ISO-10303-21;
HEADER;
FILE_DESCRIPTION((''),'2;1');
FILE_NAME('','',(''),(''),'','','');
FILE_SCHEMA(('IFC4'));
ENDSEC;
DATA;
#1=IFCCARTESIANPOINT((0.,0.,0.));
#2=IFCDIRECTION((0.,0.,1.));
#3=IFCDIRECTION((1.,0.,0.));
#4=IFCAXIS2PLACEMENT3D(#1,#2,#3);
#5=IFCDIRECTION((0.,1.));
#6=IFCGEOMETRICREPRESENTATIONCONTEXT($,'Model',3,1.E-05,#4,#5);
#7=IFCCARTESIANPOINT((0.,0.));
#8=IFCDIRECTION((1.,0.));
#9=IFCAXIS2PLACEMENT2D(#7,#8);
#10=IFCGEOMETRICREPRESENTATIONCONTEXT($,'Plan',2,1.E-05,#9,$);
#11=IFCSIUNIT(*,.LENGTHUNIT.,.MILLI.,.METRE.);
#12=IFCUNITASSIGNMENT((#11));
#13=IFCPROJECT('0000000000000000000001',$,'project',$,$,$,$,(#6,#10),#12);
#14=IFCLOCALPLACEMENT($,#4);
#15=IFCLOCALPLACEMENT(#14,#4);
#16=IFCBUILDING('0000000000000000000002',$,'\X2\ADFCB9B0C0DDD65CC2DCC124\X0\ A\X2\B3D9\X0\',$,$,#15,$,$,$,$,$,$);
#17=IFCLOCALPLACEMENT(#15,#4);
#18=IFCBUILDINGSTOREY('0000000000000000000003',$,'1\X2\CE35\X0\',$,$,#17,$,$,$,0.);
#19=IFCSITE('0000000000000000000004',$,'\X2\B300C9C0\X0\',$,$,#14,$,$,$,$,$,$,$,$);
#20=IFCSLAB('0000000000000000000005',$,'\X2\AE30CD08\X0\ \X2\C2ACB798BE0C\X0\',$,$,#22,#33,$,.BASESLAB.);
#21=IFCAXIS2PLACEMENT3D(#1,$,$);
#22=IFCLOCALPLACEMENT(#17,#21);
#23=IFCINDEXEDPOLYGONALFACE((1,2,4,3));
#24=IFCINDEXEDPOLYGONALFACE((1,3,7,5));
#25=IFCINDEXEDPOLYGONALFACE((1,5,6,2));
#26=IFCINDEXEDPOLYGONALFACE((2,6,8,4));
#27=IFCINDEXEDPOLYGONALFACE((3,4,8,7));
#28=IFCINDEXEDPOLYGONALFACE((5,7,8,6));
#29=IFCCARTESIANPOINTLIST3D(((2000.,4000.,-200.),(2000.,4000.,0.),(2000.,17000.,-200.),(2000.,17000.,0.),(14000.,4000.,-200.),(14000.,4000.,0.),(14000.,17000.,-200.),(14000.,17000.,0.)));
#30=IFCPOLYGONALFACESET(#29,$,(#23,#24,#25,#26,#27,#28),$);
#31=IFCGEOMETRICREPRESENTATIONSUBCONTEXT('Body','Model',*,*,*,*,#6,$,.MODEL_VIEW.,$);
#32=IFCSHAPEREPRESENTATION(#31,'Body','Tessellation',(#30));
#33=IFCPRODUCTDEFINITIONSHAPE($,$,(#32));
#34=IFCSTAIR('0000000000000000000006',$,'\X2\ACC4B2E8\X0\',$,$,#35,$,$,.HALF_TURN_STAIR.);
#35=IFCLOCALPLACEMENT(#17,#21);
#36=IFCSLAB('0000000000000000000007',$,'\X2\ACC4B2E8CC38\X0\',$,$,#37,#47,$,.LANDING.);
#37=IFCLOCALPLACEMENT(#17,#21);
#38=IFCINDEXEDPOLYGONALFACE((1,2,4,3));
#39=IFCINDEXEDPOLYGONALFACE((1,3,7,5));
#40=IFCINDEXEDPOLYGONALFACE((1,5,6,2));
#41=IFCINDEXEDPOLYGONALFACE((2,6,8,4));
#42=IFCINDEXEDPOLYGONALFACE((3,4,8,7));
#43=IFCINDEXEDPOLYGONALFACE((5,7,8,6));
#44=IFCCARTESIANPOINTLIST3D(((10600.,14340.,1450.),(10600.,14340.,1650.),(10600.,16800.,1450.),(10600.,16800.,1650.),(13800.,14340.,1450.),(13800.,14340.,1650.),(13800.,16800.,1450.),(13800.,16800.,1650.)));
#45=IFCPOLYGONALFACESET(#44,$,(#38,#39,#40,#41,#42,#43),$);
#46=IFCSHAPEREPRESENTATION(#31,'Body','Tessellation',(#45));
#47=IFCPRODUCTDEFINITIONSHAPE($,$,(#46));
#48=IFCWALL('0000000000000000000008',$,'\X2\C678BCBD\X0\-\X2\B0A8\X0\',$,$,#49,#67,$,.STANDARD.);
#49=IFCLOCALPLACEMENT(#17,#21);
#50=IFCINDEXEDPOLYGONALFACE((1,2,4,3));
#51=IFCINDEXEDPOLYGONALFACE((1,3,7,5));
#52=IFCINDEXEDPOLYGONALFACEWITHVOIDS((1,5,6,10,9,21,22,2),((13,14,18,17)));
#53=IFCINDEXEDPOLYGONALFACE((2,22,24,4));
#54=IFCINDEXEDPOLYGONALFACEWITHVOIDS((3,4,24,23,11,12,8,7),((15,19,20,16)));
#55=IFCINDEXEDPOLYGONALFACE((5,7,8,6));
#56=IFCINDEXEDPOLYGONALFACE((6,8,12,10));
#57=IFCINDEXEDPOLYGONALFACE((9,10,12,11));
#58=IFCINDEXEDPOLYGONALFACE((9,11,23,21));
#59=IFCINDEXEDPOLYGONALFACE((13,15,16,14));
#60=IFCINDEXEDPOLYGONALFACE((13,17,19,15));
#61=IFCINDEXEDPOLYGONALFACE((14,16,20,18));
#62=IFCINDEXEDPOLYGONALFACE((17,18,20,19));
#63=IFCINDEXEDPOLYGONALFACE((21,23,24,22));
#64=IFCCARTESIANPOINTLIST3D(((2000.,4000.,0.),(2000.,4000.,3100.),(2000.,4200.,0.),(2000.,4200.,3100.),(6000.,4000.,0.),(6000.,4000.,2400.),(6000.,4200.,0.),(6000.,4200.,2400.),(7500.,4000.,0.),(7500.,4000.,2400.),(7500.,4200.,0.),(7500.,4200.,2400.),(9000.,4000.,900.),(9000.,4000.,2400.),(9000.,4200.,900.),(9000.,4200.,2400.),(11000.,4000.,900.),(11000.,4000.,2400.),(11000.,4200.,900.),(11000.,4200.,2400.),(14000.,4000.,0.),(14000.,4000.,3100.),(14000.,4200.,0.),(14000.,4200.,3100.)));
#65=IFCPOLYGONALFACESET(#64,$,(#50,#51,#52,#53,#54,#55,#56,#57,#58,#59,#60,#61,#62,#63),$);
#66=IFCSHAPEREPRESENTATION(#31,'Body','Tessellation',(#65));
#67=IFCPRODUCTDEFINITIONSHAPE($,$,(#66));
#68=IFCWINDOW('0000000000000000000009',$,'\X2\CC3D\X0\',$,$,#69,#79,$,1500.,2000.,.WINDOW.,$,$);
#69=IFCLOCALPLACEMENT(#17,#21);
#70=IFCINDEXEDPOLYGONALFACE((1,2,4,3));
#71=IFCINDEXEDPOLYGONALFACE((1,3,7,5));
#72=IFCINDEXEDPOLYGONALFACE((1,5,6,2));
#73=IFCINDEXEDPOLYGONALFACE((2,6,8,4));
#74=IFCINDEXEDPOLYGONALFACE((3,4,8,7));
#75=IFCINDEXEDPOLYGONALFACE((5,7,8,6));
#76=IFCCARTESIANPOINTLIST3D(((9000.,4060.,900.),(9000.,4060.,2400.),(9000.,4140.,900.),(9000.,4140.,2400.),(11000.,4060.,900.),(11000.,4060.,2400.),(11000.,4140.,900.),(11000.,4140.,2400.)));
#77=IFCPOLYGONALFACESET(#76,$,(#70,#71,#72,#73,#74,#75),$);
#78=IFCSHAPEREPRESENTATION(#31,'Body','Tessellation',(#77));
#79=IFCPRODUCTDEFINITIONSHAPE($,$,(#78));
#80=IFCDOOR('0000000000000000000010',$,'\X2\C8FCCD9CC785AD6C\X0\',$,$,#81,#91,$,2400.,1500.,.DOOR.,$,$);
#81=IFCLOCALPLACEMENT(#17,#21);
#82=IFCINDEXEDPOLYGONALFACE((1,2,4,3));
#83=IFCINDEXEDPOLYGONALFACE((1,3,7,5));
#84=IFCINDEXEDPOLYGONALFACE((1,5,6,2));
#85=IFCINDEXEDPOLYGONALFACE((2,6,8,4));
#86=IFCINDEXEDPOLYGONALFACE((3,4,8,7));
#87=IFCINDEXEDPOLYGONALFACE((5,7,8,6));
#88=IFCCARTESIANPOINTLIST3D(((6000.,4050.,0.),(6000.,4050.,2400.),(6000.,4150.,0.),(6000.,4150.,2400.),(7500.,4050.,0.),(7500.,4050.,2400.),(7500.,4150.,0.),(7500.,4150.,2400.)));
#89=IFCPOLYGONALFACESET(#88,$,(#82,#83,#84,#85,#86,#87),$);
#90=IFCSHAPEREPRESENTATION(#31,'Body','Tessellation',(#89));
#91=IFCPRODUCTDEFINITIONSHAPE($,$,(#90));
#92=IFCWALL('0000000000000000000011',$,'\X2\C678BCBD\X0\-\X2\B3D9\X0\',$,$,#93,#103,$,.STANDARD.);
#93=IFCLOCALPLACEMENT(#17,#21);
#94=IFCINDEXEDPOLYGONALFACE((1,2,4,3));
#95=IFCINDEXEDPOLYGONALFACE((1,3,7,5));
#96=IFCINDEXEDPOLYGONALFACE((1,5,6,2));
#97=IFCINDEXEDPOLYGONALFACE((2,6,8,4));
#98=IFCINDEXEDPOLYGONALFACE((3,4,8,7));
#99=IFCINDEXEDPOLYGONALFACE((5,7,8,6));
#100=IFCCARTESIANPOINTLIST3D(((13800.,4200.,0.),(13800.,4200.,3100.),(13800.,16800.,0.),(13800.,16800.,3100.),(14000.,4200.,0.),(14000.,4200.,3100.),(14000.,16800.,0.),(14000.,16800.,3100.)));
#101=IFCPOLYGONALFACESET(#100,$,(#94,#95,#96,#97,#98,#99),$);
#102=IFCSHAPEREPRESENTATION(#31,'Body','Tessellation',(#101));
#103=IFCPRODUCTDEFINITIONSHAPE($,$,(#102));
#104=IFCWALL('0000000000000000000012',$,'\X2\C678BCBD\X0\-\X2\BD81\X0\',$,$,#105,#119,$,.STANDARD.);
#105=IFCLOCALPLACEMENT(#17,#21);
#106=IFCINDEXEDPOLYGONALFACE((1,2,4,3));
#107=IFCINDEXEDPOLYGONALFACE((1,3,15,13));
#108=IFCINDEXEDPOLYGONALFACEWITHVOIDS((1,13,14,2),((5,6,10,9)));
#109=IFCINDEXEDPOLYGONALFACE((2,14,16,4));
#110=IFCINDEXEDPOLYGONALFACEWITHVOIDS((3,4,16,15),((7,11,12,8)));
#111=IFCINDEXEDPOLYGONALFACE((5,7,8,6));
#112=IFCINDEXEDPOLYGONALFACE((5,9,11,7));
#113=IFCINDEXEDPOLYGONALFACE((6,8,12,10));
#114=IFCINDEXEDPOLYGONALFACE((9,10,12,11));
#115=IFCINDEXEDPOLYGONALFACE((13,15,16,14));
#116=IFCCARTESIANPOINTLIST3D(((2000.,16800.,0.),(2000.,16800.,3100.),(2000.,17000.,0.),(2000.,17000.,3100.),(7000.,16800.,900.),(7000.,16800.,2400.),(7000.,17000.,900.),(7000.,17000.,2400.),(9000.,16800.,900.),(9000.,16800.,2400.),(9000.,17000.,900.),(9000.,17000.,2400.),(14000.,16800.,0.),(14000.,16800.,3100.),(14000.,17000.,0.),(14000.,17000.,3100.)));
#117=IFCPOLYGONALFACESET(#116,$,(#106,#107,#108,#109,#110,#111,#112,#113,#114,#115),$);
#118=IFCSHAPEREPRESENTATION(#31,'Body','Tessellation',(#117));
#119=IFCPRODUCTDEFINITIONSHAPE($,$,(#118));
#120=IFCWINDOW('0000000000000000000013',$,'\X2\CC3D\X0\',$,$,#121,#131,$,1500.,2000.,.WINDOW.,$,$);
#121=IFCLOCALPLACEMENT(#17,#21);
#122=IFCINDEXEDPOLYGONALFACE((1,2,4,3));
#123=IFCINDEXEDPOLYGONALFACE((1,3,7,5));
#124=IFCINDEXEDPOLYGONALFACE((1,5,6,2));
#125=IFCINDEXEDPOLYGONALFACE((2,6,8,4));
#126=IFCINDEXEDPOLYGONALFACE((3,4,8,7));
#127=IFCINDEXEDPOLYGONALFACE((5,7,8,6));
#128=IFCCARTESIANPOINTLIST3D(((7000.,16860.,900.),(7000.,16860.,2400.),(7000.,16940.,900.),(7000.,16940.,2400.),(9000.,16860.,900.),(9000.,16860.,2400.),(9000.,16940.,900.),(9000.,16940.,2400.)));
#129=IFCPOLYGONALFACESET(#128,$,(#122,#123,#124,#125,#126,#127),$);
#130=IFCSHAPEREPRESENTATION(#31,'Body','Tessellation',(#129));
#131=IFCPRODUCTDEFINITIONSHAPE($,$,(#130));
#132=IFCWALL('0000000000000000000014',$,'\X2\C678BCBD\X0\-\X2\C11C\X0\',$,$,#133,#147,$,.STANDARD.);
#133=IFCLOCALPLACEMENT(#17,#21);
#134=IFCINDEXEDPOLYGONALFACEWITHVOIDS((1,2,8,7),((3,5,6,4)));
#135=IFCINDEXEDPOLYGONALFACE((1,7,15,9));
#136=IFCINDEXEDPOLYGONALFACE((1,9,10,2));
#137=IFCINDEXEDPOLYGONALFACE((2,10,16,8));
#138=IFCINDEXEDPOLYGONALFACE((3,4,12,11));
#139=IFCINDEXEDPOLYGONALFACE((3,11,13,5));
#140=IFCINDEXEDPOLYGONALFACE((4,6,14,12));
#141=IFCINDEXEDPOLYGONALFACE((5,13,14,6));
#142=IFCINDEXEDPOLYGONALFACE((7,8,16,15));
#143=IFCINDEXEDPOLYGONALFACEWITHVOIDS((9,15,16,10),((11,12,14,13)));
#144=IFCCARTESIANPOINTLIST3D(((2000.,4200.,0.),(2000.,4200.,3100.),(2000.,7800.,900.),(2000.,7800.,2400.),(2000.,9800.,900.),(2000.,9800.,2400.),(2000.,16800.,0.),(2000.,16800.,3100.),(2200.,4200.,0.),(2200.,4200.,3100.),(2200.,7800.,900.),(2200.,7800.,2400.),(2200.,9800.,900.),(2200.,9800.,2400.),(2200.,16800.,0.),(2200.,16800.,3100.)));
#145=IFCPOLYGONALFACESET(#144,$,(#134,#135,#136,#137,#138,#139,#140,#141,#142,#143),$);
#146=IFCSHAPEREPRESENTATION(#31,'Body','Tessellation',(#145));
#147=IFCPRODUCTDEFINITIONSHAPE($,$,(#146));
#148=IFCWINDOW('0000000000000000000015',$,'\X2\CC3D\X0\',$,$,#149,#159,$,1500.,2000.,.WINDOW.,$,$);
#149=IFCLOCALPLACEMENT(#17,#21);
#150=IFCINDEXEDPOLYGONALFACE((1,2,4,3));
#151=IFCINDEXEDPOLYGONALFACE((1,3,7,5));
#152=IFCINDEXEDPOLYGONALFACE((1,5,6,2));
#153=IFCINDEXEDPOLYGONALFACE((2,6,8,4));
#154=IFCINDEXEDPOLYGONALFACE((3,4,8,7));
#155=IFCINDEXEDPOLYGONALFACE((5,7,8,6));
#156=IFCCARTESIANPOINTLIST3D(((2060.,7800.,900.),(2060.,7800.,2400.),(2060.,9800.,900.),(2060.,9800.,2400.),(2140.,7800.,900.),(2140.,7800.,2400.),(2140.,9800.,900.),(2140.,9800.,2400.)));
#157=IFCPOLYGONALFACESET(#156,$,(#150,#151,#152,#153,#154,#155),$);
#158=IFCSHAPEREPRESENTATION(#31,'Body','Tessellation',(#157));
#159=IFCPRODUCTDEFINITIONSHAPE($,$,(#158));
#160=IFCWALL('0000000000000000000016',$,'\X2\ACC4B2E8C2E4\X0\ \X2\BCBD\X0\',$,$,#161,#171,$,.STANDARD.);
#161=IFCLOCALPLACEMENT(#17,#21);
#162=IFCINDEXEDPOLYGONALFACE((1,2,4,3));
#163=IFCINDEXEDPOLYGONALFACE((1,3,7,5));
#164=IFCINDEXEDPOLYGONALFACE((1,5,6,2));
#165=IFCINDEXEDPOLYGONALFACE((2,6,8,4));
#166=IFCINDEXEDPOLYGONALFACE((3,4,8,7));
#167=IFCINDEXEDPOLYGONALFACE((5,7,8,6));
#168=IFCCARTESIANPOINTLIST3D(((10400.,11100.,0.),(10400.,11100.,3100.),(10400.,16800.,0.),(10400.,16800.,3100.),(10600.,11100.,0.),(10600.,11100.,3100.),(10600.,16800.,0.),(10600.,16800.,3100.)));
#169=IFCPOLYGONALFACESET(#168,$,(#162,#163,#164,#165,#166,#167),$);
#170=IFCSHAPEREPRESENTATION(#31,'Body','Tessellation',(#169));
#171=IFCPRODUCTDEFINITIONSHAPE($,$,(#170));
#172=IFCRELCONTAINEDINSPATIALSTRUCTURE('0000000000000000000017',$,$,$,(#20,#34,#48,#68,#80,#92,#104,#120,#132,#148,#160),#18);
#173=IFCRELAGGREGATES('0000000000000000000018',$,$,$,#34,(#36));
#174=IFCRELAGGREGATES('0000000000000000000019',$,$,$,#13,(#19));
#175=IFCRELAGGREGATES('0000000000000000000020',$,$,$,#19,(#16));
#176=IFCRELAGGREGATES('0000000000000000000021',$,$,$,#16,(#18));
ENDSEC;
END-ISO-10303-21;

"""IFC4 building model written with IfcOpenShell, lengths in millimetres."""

from ifc_helpers import new_model, si_unit, direction, frame, origin_with_axes, origin_2d_with_axis, place, context, subcontext, project, spatial, polyline, outline, extrude, element, fill, aggregate, save


model = new_model("IFC4")

# Units and contexts
model_context = context("Model", 3, precision=1e-05, world=origin_with_axes(), true_north=direction((0.0, 1.0)))
plan_context = context("Plan", 2, precision=1e-05, world=origin_2d_with_axis())
body_context = subcontext(model_context, "Body", "Model", "MODEL_VIEW")
ifc_project = project(units=[si_unit("LENGTHUNIT", "METRE", prefix="MILLI")], contexts=[model_context, plan_context])

# Site, building, storey
site_placement = place(None, origin_with_axes())
site = spatial("IfcSite", under=ifc_project, at=site_placement, Name="대지")
building_placement = place(site_placement, origin_with_axes())
building = spatial("IfcBuilding", under=site, at=building_placement, Name="근린생활시설 A동")
storey_placement = place(building_placement, origin_with_axes())
storey = spatial("IfcBuildingStorey", under=building, at=storey_placement, Name="1층", Elevation=0.0)

# Slab
slab_1_placement = place(storey_placement, origin_with_axes())
element("IfcSlab", 1, at=slab_1_placement, inside=storey, Name="기초 슬래브", PredefinedType="BASESLAB", context=body_context, shape_type="SweptSolid", body=[
    extrude(outline(polyline([(2000.0, 4000.0), (14000.0, 4000.0), (14000.0, 17000.0), (2000.0, 17000.0), (2000.0, 4000.0)])), frame((0.0, 0.0, -200.0), z_axis=(0.0, 0.0, 1.0), x_axis=(1.0, 0.0, 0.0)), (0.0, 0.0, 1.0), 200.0),
])

# Stair, slab
stair_placement = place(storey_placement, origin_with_axes())
stair = element("IfcStair", 2, at=stair_placement, inside=storey, Name="계단", PredefinedType="HALF_TURN_STAIR")
slab_2_placement = place(stair_placement, origin_with_axes())
slab_2 = element("IfcSlab", 3, at=slab_2_placement, Name="계단참", PredefinedType="LANDING", context=body_context, shape_type="SweptSolid", body=[
    extrude(outline(polyline([(10600.0, 14340.0), (13800.0, 14340.0), (13800.0, 16800.0), (10600.0, 16800.0), (10600.0, 14340.0)])), frame((0.0, 0.0, 1450.0), z_axis=(0.0, 0.0, 1.0), x_axis=(1.0, 0.0, 0.0)), (0.0, 0.0, 1.0), 200.0),
])

# Wall, openings, window, door
wall_1_placement = place(storey_placement, origin_with_axes())
wall_1 = element("IfcWall", 4, at=wall_1_placement, inside=storey, Name="외벽-남", PredefinedType="STANDARD", context=body_context, shape_type="SweptSolid", body=[
    extrude(outline(polyline([(2000.0, 4200.0), (14000.0, 4200.0), (14000.0, 4000.0), (2000.0, 4000.0), (2000.0, 4200.0)])), origin_with_axes(), (0.0, 0.0, 1.0), 3100.0),
])
opening_1_placement = place(storey_placement, origin_with_axes())
opening_1 = element("IfcOpeningElement", 5, at=opening_1_placement, cuts=wall_1, PredefinedType="OPENING", context=body_context, shape_type="SweptSolid", body=[
    extrude(outline(polyline([(9000.0, 3950.0), (11000.0, 3950.0), (11000.0, 4250.0), (9000.0, 4250.0), (9000.0, 3950.0)])), frame((0.0, 0.0, 900.0), z_axis=(0.0, 0.0, 1.0), x_axis=(1.0, 0.0, 0.0)), (0.0, 0.0, 1.0), 1500.0),
])
opening_2_placement = place(storey_placement, origin_with_axes())
opening_2 = element("IfcOpeningElement", 6, at=opening_2_placement, cuts=wall_1, PredefinedType="OPENING", context=body_context, shape_type="SweptSolid", body=[
    extrude(outline(polyline([(6000.0, 3950.0), (7500.0, 3950.0), (7500.0, 4250.0), (6000.0, 4250.0), (6000.0, 3950.0)])), origin_with_axes(), (0.0, 0.0, 1.0), 2400.0),
])
window_1_placement = place(storey_placement, origin_with_axes())
window_1 = element("IfcWindow", 7, at=window_1_placement, inside=storey, Name="창", OverallHeight=1500.0, OverallWidth=2000.0, PredefinedType="WINDOW", context=body_context, shape_type="SweptSolid", body=[
    extrude(outline(polyline([(9000.0, 4060.0), (11000.0, 4060.0), (11000.0, 4140.0), (9000.0, 4140.0), (9000.0, 4060.0)])), frame((0.0, 0.0, 900.0), z_axis=(0.0, 0.0, 1.0), x_axis=(1.0, 0.0, 0.0)), (0.0, 0.0, 1.0), 1500.0),
])
fill(opening_1, window_1)
door_1_placement = place(storey_placement, origin_with_axes())
door_1 = element("IfcDoor", 8, at=door_1_placement, inside=storey, Name="주출입구", OverallHeight=2400.0, OverallWidth=1500.0, PredefinedType="DOOR", context=body_context, shape_type="SweptSolid", body=[
    extrude(outline(polyline([(6000.0, 4050.0), (7500.0, 4050.0), (7500.0, 4150.0), (6000.0, 4150.0), (6000.0, 4050.0)])), origin_with_axes(), (0.0, 0.0, 1.0), 2400.0),
])
fill(opening_2, door_1)

# Wall
wall_2_placement = place(storey_placement, origin_with_axes())
element("IfcWall", 9, at=wall_2_placement, inside=storey, Name="외벽-동", PredefinedType="STANDARD", context=body_context, shape_type="SweptSolid", body=[
    extrude(outline(polyline([(13800.0, 4200.0), (13800.0, 16800.0), (14000.0, 16800.0), (14000.0, 4200.0), (13800.0, 4200.0)])), origin_with_axes(), (0.0, 0.0, 1.0), 3100.0),
])

# Walls, openings, windows
wall_3_placement = place(storey_placement, origin_with_axes())
wall_3 = element("IfcWall", 10, at=wall_3_placement, inside=storey, Name="외벽-북", PredefinedType="STANDARD", context=body_context, shape_type="SweptSolid", body=[
    extrude(outline(polyline([(14000.0, 16800.0), (2000.0, 16800.0), (2000.0, 17000.0), (14000.0, 17000.0), (14000.0, 16800.0)])), origin_with_axes(), (0.0, 0.0, 1.0), 3100.0),
])
opening_3_placement = place(storey_placement, origin_with_axes())
opening_3 = element("IfcOpeningElement", 11, at=opening_3_placement, cuts=wall_3, PredefinedType="OPENING", context=body_context, shape_type="SweptSolid", body=[
    extrude(outline(polyline([(9000.0, 17050.0), (7000.0, 17050.0), (7000.0, 16750.0), (9000.0, 16750.0), (9000.0, 17050.0)])), frame((0.0, 0.0, 900.0), z_axis=(0.0, 0.0, 1.0), x_axis=(1.0, 0.0, 0.0)), (0.0, 0.0, 1.0), 1500.0),
])
window_2_placement = place(storey_placement, origin_with_axes())
window_2 = element("IfcWindow", 12, at=window_2_placement, inside=storey, Name="창", OverallHeight=1500.0, OverallWidth=2000.0, PredefinedType="WINDOW", context=body_context, shape_type="SweptSolid", body=[
    extrude(outline(polyline([(9000.0, 16940.0), (7000.0, 16940.0), (7000.0, 16860.0), (9000.0, 16860.0), (9000.0, 16940.0)])), frame((0.0, 0.0, 900.0), z_axis=(0.0, 0.0, 1.0), x_axis=(1.0, 0.0, 0.0)), (0.0, 0.0, 1.0), 1500.0),
])
fill(opening_3, window_2)
wall_4_placement = place(storey_placement, origin_with_axes())
wall_4 = element("IfcWall", 13, at=wall_4_placement, inside=storey, Name="외벽-서", PredefinedType="STANDARD", context=body_context, shape_type="SweptSolid", body=[
    extrude(outline(polyline([(2200.0, 16800.0), (2200.0, 4200.0), (2000.0, 4200.0), (2000.0, 16800.0), (2200.0, 16800.0)])), origin_with_axes(), (0.0, 0.0, 1.0), 3100.0),
])
opening_4_placement = place(storey_placement, origin_with_axes())
opening_4 = element("IfcOpeningElement", 14, at=opening_4_placement, cuts=wall_4, PredefinedType="OPENING", context=body_context, shape_type="SweptSolid", body=[
    extrude(outline(polyline([(1950.0, 9800.0), (1950.0, 7800.0), (2250.0, 7800.0), (2250.0, 9800.0), (1950.0, 9800.0)])), frame((0.0, 0.0, 900.0), z_axis=(0.0, 0.0, 1.0), x_axis=(1.0, 0.0, 0.0)), (0.0, 0.0, 1.0), 1500.0),
])
window_3_placement = place(storey_placement, origin_with_axes())
window_3 = element("IfcWindow", 15, at=window_3_placement, inside=storey, Name="창", OverallHeight=1500.0, OverallWidth=2000.0, PredefinedType="WINDOW", context=body_context, shape_type="SweptSolid", body=[
    extrude(outline(polyline([(2060.0, 9800.0), (2060.0, 7800.0), (2140.0, 7800.0), (2140.0, 9800.0), (2060.0, 9800.0)])), frame((0.0, 0.0, 900.0), z_axis=(0.0, 0.0, 1.0), x_axis=(1.0, 0.0, 0.0)), (0.0, 0.0, 1.0), 1500.0),
])
fill(opening_4, window_3)

# Wall
wall_5_placement = place(storey_placement, origin_with_axes())
element("IfcWall", 16, at=wall_5_placement, inside=storey, Name="계단실 벽", PredefinedType="STANDARD", context=body_context, shape_type="SweptSolid", body=[
    extrude(outline(polyline([(10400.0, 11100.0), (10400.0, 16800.0), (10600.0, 16800.0), (10600.0, 11100.0), (10400.0, 11100.0)])), origin_with_axes(), (0.0, 0.0, 1.0), 3100.0),
])

aggregate(stair, [slab_2])

save(model, "model.ifc")
